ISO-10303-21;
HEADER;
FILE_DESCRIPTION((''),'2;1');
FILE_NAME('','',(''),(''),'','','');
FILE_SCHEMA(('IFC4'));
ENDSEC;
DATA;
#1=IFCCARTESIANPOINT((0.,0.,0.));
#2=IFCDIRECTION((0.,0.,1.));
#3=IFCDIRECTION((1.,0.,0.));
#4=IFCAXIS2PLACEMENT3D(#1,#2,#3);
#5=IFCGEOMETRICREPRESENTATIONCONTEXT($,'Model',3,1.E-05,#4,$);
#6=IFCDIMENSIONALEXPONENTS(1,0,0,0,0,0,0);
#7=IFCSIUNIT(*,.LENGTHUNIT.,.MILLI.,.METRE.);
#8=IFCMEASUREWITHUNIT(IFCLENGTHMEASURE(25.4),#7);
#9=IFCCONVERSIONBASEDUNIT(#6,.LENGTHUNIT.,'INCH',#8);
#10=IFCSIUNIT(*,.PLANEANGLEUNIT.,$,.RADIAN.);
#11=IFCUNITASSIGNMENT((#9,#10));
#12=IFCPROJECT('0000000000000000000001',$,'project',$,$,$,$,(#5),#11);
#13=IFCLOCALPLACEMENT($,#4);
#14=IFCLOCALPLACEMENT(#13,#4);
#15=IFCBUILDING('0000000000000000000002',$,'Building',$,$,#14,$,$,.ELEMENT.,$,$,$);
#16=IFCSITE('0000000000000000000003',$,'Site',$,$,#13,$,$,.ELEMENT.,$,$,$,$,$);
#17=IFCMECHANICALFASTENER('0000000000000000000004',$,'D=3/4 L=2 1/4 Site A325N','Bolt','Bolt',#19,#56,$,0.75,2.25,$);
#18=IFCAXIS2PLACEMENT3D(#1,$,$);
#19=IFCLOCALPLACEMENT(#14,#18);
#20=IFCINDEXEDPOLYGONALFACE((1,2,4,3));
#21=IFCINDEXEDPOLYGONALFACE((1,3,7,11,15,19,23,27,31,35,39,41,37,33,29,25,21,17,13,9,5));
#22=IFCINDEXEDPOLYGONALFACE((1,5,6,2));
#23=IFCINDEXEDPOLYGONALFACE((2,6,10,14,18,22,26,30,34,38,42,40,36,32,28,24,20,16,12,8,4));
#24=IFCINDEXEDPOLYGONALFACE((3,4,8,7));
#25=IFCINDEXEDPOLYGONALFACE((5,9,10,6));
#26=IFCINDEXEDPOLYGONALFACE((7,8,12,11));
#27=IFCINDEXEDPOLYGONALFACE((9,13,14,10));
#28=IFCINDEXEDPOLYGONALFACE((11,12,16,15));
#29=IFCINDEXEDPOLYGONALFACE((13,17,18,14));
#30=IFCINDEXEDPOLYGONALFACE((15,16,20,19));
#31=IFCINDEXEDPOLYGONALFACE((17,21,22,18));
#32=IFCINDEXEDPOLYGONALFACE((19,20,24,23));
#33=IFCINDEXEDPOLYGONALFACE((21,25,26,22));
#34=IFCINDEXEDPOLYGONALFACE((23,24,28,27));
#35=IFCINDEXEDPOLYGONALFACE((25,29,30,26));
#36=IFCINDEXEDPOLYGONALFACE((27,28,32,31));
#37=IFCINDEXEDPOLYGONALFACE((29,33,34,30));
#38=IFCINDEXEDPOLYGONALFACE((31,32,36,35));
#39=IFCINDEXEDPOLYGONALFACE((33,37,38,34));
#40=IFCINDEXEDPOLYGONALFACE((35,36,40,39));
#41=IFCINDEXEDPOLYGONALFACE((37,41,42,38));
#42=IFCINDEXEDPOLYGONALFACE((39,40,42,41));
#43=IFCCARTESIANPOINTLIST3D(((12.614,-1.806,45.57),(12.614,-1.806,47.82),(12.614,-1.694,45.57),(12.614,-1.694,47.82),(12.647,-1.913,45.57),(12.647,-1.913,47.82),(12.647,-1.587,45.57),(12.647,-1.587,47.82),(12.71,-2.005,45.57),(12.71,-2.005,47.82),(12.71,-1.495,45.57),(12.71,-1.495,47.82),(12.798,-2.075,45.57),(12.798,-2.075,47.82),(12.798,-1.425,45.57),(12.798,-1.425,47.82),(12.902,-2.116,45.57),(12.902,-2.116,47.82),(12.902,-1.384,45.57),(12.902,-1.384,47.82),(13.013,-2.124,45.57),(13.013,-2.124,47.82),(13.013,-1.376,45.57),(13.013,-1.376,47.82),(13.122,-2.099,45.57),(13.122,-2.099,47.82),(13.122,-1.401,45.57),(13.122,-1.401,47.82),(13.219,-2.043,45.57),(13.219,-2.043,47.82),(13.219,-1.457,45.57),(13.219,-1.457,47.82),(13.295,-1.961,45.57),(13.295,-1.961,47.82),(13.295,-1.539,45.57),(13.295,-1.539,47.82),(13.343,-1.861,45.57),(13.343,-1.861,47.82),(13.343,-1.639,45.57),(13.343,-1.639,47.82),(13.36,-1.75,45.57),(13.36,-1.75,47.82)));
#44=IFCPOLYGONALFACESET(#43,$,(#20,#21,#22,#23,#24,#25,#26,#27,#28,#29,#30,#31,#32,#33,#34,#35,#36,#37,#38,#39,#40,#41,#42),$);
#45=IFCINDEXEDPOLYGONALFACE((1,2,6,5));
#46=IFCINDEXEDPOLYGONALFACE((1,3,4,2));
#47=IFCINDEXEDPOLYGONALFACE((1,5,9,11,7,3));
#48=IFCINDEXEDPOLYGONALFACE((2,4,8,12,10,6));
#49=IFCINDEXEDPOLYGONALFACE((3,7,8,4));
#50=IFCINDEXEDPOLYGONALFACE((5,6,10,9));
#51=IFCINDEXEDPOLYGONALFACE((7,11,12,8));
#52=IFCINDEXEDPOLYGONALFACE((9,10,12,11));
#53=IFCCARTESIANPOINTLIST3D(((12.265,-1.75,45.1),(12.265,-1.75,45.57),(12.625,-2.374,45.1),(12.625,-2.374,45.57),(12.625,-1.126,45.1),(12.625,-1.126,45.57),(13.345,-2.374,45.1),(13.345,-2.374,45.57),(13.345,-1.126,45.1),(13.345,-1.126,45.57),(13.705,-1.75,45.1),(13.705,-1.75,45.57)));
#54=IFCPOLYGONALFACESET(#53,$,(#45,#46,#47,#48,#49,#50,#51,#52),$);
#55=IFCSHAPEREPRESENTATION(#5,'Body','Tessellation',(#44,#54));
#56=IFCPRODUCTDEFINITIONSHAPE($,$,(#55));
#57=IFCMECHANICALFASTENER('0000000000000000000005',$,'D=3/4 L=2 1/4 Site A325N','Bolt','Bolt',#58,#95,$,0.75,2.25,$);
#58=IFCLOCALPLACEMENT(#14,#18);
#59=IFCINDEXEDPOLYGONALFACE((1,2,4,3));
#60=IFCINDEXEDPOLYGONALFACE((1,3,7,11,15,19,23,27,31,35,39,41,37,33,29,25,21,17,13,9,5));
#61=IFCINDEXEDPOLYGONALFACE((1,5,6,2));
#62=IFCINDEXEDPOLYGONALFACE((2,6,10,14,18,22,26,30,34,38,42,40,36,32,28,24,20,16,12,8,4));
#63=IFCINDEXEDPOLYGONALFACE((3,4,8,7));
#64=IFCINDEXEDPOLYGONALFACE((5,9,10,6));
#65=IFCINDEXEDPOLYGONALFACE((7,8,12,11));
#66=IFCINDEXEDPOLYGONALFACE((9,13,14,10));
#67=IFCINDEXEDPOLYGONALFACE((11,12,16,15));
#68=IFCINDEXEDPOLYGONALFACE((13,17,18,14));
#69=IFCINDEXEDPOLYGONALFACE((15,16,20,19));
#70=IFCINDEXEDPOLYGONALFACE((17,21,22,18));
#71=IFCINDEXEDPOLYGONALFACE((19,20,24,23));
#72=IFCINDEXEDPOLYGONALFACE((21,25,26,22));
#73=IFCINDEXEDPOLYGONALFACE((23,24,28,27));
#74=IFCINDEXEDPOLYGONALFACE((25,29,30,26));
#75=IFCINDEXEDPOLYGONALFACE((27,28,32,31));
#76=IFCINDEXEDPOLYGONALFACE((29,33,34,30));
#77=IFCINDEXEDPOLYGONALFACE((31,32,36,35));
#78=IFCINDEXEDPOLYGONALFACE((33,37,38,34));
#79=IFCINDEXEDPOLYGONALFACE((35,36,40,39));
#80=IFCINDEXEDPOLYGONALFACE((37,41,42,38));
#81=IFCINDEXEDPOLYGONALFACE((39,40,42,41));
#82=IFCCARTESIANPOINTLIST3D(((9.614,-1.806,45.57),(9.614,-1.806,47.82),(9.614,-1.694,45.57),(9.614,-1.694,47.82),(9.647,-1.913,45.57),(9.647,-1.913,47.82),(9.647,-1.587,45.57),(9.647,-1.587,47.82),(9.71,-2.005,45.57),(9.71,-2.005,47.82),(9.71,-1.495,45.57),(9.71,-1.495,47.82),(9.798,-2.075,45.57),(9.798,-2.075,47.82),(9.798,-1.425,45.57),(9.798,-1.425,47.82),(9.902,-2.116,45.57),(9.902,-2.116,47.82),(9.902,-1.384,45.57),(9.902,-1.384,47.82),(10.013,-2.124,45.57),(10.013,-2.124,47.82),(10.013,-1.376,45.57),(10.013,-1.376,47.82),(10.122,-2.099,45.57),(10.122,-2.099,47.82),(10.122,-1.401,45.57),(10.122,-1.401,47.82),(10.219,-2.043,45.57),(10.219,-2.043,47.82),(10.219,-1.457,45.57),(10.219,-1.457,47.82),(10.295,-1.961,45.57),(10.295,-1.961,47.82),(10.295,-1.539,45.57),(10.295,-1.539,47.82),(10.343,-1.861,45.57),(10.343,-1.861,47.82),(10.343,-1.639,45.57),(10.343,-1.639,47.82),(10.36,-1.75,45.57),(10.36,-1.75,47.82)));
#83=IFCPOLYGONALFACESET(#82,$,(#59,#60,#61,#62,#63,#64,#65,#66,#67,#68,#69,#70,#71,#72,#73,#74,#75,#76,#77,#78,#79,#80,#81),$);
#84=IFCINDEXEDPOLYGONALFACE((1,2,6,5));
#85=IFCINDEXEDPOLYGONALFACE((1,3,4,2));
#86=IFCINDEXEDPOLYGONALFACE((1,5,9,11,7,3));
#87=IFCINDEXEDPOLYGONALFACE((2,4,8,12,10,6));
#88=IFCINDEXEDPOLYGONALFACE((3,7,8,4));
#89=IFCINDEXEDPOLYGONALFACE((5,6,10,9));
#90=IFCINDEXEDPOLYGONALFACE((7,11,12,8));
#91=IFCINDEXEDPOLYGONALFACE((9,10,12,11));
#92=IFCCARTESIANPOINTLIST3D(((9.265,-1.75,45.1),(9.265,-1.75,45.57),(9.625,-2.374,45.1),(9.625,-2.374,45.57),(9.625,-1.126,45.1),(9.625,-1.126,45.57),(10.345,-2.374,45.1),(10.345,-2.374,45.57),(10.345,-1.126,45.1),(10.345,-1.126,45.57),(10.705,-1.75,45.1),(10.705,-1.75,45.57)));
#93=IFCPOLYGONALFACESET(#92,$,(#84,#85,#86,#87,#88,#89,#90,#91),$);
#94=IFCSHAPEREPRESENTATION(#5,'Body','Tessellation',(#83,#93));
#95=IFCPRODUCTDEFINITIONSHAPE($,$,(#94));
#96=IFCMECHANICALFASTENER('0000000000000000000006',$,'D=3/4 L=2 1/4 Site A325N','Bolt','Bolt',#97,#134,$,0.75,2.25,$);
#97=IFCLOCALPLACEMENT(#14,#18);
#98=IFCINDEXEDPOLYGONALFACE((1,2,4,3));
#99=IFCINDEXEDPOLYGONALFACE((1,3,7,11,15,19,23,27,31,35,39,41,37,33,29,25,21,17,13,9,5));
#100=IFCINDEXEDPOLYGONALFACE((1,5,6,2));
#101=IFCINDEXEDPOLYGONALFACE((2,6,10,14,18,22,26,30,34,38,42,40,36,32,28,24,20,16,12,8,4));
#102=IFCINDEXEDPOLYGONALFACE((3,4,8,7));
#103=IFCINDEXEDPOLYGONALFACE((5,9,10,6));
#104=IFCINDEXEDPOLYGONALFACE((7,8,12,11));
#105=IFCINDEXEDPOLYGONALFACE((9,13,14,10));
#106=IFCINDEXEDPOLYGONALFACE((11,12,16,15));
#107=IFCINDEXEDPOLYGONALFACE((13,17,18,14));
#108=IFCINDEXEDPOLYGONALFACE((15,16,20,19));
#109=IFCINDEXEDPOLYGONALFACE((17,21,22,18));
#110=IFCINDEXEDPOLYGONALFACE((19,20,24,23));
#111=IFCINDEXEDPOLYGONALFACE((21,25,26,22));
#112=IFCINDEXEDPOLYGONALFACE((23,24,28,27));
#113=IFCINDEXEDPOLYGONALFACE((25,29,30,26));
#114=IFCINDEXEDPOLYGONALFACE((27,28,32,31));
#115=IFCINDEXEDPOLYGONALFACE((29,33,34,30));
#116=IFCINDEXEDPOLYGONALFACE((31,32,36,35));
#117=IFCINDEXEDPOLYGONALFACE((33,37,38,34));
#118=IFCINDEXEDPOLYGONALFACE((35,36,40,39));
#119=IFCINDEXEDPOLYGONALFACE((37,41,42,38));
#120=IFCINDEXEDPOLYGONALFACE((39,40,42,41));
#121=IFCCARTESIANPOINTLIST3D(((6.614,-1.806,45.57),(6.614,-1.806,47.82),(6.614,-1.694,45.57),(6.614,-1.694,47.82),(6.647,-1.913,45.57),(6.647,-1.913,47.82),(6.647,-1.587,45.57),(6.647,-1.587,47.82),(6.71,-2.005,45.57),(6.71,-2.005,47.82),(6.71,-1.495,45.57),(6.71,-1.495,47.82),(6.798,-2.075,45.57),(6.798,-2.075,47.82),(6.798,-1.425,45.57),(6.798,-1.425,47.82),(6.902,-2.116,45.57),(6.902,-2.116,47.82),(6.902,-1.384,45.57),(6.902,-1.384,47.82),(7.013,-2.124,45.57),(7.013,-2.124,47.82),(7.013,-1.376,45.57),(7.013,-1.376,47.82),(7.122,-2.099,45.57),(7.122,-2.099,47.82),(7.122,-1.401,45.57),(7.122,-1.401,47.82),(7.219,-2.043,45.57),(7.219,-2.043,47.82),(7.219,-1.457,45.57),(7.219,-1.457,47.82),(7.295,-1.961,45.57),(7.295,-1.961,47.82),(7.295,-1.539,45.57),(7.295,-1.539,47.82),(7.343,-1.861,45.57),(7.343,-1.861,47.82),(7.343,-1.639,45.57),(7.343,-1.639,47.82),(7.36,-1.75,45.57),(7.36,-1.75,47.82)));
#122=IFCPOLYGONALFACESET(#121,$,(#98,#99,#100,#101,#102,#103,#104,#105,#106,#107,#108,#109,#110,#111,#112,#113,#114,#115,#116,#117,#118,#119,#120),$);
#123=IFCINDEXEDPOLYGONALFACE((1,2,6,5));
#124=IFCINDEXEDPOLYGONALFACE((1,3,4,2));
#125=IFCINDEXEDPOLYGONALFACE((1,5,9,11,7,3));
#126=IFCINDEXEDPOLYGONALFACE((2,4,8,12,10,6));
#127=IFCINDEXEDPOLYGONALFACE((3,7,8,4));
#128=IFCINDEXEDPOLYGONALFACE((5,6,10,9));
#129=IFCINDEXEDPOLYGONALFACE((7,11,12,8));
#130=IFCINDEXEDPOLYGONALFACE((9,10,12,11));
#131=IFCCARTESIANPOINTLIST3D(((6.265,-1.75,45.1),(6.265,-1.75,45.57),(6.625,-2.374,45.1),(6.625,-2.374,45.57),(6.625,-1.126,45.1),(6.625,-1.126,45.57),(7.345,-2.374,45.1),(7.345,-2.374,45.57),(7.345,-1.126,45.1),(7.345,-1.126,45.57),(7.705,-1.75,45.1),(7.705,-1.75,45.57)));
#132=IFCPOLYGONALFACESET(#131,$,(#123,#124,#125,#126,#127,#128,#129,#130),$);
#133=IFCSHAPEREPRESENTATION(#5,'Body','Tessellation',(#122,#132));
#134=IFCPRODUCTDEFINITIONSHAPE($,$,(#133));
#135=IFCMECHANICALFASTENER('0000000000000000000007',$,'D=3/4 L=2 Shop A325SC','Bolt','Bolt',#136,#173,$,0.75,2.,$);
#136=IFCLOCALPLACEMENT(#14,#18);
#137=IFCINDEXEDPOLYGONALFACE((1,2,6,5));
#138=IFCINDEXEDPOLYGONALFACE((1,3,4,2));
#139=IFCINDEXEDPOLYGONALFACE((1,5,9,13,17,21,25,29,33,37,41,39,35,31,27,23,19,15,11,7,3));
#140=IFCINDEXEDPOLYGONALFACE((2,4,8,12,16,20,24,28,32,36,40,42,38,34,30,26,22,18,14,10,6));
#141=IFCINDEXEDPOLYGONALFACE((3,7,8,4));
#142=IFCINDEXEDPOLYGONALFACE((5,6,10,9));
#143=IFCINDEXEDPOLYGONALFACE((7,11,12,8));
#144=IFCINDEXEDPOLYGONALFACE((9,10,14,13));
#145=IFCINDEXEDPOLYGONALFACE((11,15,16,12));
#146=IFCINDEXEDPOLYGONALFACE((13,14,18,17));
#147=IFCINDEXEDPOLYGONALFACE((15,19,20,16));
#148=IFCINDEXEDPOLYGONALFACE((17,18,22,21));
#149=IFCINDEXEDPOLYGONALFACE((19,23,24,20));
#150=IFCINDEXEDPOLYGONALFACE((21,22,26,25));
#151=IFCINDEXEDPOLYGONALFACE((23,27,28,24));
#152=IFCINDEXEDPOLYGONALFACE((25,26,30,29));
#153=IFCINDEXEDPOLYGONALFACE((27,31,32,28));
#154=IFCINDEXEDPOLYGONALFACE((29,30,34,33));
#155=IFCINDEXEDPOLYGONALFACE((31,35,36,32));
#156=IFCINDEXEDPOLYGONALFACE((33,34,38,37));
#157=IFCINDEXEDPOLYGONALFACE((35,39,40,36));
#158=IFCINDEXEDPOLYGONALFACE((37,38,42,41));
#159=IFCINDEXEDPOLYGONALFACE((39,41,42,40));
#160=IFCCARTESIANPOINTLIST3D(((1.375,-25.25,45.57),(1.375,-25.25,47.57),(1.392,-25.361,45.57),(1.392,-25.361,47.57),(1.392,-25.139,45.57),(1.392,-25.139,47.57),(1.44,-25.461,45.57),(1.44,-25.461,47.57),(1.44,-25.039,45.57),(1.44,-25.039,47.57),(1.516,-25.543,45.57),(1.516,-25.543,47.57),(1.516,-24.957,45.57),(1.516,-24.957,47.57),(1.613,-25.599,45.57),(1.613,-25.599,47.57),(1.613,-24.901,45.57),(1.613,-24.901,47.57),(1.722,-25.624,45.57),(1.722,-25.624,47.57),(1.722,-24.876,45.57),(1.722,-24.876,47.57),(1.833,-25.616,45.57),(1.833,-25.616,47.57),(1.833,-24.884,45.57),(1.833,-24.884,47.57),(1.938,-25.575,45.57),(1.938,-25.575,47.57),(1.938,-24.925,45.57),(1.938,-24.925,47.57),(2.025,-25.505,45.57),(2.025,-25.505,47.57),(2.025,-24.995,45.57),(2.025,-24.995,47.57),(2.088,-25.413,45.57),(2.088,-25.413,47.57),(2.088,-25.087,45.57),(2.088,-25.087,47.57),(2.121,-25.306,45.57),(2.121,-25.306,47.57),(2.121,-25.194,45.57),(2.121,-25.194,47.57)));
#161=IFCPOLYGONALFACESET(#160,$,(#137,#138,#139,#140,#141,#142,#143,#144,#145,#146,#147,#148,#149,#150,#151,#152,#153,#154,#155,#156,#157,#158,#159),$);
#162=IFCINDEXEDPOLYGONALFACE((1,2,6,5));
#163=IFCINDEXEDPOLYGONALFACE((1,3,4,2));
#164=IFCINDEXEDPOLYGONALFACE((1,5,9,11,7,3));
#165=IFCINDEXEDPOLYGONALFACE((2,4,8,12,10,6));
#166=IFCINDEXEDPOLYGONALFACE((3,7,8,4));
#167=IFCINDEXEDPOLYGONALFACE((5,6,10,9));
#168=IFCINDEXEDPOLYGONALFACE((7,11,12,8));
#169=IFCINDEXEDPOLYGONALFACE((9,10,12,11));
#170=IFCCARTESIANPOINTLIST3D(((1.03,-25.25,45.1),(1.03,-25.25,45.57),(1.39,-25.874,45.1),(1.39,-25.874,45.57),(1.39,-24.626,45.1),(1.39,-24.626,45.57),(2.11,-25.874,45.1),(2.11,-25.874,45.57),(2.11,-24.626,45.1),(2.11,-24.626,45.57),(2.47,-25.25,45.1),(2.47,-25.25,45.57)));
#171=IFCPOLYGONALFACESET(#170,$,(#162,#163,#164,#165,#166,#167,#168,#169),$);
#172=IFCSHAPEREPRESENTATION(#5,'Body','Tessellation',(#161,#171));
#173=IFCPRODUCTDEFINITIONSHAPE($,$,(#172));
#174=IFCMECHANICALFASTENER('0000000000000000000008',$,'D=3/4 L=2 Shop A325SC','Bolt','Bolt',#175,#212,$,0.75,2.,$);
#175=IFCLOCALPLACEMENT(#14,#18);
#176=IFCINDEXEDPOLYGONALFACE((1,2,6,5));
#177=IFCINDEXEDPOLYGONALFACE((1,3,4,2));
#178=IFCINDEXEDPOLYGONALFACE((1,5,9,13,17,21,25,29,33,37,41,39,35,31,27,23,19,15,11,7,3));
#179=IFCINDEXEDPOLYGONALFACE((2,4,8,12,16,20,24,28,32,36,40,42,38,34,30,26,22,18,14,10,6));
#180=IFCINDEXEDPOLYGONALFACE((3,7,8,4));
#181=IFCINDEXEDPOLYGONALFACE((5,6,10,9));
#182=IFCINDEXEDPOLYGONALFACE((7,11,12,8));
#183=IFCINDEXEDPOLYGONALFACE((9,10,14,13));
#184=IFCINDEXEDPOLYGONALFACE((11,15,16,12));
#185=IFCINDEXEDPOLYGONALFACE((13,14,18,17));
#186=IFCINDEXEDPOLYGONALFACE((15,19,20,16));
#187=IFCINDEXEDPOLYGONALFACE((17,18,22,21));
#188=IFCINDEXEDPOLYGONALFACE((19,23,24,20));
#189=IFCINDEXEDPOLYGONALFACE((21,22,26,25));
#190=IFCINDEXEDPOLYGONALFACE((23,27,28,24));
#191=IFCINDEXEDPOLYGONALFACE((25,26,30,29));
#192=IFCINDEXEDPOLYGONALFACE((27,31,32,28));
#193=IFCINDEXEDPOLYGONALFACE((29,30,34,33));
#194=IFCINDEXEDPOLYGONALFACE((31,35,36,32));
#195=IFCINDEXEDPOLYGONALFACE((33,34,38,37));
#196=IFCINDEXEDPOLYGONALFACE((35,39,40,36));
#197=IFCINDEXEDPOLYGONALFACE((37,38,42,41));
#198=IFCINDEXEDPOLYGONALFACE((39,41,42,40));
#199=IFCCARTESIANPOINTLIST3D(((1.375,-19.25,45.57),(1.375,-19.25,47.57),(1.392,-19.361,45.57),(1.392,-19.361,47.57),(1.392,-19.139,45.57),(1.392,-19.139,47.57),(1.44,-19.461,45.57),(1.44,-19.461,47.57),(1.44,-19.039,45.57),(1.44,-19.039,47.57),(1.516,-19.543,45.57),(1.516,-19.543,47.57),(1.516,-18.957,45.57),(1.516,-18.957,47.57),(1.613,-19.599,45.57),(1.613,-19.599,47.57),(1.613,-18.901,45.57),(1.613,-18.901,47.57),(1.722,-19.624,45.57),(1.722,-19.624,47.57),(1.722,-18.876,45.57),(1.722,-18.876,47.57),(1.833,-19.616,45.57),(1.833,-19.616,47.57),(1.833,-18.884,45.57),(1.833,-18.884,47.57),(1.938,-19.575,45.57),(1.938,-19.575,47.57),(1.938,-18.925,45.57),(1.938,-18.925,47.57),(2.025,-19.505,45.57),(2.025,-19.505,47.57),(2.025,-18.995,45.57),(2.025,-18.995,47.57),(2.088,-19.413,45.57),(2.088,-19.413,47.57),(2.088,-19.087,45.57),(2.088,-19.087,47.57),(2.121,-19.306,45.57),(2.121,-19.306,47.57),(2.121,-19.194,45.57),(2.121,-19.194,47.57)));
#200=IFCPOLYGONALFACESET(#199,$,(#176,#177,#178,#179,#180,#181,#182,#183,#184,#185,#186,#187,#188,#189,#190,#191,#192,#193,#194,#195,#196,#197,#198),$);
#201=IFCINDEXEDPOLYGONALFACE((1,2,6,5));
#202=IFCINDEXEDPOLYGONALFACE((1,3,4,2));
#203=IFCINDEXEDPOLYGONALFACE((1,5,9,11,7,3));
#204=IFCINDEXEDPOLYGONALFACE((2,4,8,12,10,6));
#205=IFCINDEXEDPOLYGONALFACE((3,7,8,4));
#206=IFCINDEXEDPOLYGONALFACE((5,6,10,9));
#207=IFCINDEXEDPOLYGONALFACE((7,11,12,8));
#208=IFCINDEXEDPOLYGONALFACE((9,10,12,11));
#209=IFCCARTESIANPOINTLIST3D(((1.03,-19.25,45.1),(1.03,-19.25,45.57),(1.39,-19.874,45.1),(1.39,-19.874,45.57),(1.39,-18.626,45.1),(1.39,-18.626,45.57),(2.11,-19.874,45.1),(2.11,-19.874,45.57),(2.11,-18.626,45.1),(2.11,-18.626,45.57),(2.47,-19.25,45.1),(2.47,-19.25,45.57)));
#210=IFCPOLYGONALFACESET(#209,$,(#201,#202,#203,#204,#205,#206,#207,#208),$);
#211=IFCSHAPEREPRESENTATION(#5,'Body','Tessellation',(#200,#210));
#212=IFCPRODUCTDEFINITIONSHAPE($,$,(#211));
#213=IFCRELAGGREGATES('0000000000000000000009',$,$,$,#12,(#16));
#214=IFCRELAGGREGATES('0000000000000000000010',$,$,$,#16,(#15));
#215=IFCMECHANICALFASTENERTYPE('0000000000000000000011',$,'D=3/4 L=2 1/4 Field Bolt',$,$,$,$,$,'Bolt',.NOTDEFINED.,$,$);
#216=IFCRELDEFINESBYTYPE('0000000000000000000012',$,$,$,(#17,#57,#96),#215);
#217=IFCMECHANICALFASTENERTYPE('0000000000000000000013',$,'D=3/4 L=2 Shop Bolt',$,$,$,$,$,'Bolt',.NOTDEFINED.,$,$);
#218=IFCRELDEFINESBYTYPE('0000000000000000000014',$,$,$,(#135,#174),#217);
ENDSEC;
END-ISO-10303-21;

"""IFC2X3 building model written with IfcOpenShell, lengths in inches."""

from ifc_helpers import new_model, entity, si_unit, converted_unit, frame, origin_with_axes, origin_2d_with_axis, place, context, project, spatial, polyline, circle, outline, extrude, source, transform, mapped, type_object, type_shapes, element, save


model = new_model("IFC2X3")

# Units and contexts
model_context = context("Model", 3, precision=1e-05, world=origin_with_axes())
ifc_project = project(units=[converted_unit("LENGTHUNIT", "INCH", entity("IfcLengthMeasure", 25.4), si_unit("LENGTHUNIT", "METRE", prefix="MILLI"), dimensions=[1, 0, 0, 0, 0, 0, 0]), si_unit("PLANEANGLEUNIT", "RADIAN")], contexts=[model_context])

# Site, building
site_placement = place(None, origin_with_axes())
site = spatial("IfcSite", under=ifc_project, at=site_placement, Name="Site", CompositionType="ELEMENT")
building_placement = place(site_placement, origin_with_axes())
building = spatial("IfcBuilding", under=site, at=building_placement, Name="Building", CompositionType="ELEMENT")

# Mechanical fasteners
placement_1 = place(building_placement, frame((0.0, 0.0, 46.0), z_axis=(0.0, 0.0, 1.0), x_axis=(1.0, 0.0, 0.0)))
mechanical_fastener_type_1 = type_object("IfcMechanicalFastenerType", Name="D=3/4 L=2 1/4 Field Bolt", ElementType="Bolt")
shared_shape_1 = source(origin_with_axes(), model_context, "Body", "SweptSolid", [
    extrude(circle(Radius=0.375, at=origin_2d_with_axis()), frame((0.0, 0.0, 0.0), z_axis=(1.0, 0.0, 0.0), x_axis=(0.0, 1.0, 0.0)), (0.0, 0.0, 1.0), 2.25),
    extrude(outline(polyline([(-0.72, 0.0), (-0.36, 0.624), (0.36, 0.624), (0.72, 0.0), (0.36, -0.624), (-0.36, -0.624), (-0.72, 0.0)])), frame((0.0, 0.0, 0.0), z_axis=(1.0, 0.0, 0.0), x_axis=(0.0, 1.0, 0.0)), (0.0, 0.0, -1.0), 0.47),
])
type_shapes(mechanical_fastener_type_1, [shared_shape_1])
placement_2 = place(placement_1, frame((6.985, 1.75, -0.43), z_axis=(0.0, 1.0, 0.0), x_axis=(0.0, 0.0, 1.0)))
for number, where, z_axis, x_axis, name in (
    (1, (0.0, 6.0, -3.5), (0.0, 0.0, 1.0), (1.0, 0.0, 0.0), "D=3/4 L=2 1/4 Site A325N"),
    (2, (0.0, 3.0, -3.5), (0.0, 0.0, 1.0), (1.0, 0.0, 0.0), "D=3/4 L=2 1/4 Site A325N"),
    (3, (0.0, 0.0, -3.5), (0.0, 0.0, 1.0), (1.0, 0.0, 0.0), "D=3/4 L=2 1/4 Site A325N"),
):
    element("IfcMechanicalFastener", number, at=place(placement_2, frame(where, z_axis=z_axis, x_axis=x_axis)), type_object=mechanical_fastener_type_1, Name=name, Description="Bolt", ObjectType="Bolt", NominalDiameter=0.75, NominalLength=2.25, context=model_context, shape_type="MappedRepresentation", body=[
        mapped(shared_shape_1, transform((0.0, 0.0, 0.0), scale=1.0)),
    ])
mechanical_fastener_type_2 = type_object("IfcMechanicalFastenerType", Name="D=3/4 L=2 Shop Bolt", ElementType="Bolt")
shared_shape_2 = source(origin_with_axes(), model_context, "Body", "SweptSolid", [
    extrude(circle(Radius=0.375, at=origin_2d_with_axis()), frame((0.0, 0.0, 0.0), z_axis=(1.0, 0.0, 0.0), x_axis=(0.0, 1.0, 0.0)), (0.0, 0.0, 1.0), 2.0),
    extrude(outline(polyline([(-0.72, 0.0), (-0.36, 0.624), (0.36, 0.624), (0.72, 0.0), (0.36, -0.624), (-0.36, -0.624), (-0.72, 0.0)])), frame((0.0, 0.0, 0.0), z_axis=(1.0, 0.0, 0.0), x_axis=(0.0, 1.0, 0.0)), (0.0, 0.0, -1.0), 0.47),
])
type_shapes(mechanical_fastener_type_2, [shared_shape_2])
placement_3 = place(building_placement, frame((0.0, 0.0, 46.0), z_axis=(0.0, 0.0, 1.0), x_axis=(0.0, -1.0, 0.0)))
placement_4 = place(placement_3, frame((25.25, -1.75, -0.43), z_axis=(1.0, 0.0, 0.0), x_axis=(0.0, 0.0, 1.0)))
for number, where, z_axis, x_axis, name in (
    (4, (0.0, -3.5, 0.0), (0.0, 0.0, 1.0), (1.0, 0.0, 0.0), "D=3/4 L=2 Shop A325SC"),
    (5, (0.0, -3.5, -6.0), (0.0, 0.0, 1.0), (1.0, 0.0, 0.0), "D=3/4 L=2 Shop A325SC"),
):
    element("IfcMechanicalFastener", number, at=place(placement_4, frame(where, z_axis=z_axis, x_axis=x_axis)), type_object=mechanical_fastener_type_2, Name=name, Description="Bolt", ObjectType="Bolt", NominalDiameter=0.75, NominalLength=2.0, context=model_context, shape_type="MappedRepresentation", body=[
        mapped(shared_shape_2, transform((0.0, 0.0, 0.0), scale=1.0)),
    ])

save(model, "model.ifc")
